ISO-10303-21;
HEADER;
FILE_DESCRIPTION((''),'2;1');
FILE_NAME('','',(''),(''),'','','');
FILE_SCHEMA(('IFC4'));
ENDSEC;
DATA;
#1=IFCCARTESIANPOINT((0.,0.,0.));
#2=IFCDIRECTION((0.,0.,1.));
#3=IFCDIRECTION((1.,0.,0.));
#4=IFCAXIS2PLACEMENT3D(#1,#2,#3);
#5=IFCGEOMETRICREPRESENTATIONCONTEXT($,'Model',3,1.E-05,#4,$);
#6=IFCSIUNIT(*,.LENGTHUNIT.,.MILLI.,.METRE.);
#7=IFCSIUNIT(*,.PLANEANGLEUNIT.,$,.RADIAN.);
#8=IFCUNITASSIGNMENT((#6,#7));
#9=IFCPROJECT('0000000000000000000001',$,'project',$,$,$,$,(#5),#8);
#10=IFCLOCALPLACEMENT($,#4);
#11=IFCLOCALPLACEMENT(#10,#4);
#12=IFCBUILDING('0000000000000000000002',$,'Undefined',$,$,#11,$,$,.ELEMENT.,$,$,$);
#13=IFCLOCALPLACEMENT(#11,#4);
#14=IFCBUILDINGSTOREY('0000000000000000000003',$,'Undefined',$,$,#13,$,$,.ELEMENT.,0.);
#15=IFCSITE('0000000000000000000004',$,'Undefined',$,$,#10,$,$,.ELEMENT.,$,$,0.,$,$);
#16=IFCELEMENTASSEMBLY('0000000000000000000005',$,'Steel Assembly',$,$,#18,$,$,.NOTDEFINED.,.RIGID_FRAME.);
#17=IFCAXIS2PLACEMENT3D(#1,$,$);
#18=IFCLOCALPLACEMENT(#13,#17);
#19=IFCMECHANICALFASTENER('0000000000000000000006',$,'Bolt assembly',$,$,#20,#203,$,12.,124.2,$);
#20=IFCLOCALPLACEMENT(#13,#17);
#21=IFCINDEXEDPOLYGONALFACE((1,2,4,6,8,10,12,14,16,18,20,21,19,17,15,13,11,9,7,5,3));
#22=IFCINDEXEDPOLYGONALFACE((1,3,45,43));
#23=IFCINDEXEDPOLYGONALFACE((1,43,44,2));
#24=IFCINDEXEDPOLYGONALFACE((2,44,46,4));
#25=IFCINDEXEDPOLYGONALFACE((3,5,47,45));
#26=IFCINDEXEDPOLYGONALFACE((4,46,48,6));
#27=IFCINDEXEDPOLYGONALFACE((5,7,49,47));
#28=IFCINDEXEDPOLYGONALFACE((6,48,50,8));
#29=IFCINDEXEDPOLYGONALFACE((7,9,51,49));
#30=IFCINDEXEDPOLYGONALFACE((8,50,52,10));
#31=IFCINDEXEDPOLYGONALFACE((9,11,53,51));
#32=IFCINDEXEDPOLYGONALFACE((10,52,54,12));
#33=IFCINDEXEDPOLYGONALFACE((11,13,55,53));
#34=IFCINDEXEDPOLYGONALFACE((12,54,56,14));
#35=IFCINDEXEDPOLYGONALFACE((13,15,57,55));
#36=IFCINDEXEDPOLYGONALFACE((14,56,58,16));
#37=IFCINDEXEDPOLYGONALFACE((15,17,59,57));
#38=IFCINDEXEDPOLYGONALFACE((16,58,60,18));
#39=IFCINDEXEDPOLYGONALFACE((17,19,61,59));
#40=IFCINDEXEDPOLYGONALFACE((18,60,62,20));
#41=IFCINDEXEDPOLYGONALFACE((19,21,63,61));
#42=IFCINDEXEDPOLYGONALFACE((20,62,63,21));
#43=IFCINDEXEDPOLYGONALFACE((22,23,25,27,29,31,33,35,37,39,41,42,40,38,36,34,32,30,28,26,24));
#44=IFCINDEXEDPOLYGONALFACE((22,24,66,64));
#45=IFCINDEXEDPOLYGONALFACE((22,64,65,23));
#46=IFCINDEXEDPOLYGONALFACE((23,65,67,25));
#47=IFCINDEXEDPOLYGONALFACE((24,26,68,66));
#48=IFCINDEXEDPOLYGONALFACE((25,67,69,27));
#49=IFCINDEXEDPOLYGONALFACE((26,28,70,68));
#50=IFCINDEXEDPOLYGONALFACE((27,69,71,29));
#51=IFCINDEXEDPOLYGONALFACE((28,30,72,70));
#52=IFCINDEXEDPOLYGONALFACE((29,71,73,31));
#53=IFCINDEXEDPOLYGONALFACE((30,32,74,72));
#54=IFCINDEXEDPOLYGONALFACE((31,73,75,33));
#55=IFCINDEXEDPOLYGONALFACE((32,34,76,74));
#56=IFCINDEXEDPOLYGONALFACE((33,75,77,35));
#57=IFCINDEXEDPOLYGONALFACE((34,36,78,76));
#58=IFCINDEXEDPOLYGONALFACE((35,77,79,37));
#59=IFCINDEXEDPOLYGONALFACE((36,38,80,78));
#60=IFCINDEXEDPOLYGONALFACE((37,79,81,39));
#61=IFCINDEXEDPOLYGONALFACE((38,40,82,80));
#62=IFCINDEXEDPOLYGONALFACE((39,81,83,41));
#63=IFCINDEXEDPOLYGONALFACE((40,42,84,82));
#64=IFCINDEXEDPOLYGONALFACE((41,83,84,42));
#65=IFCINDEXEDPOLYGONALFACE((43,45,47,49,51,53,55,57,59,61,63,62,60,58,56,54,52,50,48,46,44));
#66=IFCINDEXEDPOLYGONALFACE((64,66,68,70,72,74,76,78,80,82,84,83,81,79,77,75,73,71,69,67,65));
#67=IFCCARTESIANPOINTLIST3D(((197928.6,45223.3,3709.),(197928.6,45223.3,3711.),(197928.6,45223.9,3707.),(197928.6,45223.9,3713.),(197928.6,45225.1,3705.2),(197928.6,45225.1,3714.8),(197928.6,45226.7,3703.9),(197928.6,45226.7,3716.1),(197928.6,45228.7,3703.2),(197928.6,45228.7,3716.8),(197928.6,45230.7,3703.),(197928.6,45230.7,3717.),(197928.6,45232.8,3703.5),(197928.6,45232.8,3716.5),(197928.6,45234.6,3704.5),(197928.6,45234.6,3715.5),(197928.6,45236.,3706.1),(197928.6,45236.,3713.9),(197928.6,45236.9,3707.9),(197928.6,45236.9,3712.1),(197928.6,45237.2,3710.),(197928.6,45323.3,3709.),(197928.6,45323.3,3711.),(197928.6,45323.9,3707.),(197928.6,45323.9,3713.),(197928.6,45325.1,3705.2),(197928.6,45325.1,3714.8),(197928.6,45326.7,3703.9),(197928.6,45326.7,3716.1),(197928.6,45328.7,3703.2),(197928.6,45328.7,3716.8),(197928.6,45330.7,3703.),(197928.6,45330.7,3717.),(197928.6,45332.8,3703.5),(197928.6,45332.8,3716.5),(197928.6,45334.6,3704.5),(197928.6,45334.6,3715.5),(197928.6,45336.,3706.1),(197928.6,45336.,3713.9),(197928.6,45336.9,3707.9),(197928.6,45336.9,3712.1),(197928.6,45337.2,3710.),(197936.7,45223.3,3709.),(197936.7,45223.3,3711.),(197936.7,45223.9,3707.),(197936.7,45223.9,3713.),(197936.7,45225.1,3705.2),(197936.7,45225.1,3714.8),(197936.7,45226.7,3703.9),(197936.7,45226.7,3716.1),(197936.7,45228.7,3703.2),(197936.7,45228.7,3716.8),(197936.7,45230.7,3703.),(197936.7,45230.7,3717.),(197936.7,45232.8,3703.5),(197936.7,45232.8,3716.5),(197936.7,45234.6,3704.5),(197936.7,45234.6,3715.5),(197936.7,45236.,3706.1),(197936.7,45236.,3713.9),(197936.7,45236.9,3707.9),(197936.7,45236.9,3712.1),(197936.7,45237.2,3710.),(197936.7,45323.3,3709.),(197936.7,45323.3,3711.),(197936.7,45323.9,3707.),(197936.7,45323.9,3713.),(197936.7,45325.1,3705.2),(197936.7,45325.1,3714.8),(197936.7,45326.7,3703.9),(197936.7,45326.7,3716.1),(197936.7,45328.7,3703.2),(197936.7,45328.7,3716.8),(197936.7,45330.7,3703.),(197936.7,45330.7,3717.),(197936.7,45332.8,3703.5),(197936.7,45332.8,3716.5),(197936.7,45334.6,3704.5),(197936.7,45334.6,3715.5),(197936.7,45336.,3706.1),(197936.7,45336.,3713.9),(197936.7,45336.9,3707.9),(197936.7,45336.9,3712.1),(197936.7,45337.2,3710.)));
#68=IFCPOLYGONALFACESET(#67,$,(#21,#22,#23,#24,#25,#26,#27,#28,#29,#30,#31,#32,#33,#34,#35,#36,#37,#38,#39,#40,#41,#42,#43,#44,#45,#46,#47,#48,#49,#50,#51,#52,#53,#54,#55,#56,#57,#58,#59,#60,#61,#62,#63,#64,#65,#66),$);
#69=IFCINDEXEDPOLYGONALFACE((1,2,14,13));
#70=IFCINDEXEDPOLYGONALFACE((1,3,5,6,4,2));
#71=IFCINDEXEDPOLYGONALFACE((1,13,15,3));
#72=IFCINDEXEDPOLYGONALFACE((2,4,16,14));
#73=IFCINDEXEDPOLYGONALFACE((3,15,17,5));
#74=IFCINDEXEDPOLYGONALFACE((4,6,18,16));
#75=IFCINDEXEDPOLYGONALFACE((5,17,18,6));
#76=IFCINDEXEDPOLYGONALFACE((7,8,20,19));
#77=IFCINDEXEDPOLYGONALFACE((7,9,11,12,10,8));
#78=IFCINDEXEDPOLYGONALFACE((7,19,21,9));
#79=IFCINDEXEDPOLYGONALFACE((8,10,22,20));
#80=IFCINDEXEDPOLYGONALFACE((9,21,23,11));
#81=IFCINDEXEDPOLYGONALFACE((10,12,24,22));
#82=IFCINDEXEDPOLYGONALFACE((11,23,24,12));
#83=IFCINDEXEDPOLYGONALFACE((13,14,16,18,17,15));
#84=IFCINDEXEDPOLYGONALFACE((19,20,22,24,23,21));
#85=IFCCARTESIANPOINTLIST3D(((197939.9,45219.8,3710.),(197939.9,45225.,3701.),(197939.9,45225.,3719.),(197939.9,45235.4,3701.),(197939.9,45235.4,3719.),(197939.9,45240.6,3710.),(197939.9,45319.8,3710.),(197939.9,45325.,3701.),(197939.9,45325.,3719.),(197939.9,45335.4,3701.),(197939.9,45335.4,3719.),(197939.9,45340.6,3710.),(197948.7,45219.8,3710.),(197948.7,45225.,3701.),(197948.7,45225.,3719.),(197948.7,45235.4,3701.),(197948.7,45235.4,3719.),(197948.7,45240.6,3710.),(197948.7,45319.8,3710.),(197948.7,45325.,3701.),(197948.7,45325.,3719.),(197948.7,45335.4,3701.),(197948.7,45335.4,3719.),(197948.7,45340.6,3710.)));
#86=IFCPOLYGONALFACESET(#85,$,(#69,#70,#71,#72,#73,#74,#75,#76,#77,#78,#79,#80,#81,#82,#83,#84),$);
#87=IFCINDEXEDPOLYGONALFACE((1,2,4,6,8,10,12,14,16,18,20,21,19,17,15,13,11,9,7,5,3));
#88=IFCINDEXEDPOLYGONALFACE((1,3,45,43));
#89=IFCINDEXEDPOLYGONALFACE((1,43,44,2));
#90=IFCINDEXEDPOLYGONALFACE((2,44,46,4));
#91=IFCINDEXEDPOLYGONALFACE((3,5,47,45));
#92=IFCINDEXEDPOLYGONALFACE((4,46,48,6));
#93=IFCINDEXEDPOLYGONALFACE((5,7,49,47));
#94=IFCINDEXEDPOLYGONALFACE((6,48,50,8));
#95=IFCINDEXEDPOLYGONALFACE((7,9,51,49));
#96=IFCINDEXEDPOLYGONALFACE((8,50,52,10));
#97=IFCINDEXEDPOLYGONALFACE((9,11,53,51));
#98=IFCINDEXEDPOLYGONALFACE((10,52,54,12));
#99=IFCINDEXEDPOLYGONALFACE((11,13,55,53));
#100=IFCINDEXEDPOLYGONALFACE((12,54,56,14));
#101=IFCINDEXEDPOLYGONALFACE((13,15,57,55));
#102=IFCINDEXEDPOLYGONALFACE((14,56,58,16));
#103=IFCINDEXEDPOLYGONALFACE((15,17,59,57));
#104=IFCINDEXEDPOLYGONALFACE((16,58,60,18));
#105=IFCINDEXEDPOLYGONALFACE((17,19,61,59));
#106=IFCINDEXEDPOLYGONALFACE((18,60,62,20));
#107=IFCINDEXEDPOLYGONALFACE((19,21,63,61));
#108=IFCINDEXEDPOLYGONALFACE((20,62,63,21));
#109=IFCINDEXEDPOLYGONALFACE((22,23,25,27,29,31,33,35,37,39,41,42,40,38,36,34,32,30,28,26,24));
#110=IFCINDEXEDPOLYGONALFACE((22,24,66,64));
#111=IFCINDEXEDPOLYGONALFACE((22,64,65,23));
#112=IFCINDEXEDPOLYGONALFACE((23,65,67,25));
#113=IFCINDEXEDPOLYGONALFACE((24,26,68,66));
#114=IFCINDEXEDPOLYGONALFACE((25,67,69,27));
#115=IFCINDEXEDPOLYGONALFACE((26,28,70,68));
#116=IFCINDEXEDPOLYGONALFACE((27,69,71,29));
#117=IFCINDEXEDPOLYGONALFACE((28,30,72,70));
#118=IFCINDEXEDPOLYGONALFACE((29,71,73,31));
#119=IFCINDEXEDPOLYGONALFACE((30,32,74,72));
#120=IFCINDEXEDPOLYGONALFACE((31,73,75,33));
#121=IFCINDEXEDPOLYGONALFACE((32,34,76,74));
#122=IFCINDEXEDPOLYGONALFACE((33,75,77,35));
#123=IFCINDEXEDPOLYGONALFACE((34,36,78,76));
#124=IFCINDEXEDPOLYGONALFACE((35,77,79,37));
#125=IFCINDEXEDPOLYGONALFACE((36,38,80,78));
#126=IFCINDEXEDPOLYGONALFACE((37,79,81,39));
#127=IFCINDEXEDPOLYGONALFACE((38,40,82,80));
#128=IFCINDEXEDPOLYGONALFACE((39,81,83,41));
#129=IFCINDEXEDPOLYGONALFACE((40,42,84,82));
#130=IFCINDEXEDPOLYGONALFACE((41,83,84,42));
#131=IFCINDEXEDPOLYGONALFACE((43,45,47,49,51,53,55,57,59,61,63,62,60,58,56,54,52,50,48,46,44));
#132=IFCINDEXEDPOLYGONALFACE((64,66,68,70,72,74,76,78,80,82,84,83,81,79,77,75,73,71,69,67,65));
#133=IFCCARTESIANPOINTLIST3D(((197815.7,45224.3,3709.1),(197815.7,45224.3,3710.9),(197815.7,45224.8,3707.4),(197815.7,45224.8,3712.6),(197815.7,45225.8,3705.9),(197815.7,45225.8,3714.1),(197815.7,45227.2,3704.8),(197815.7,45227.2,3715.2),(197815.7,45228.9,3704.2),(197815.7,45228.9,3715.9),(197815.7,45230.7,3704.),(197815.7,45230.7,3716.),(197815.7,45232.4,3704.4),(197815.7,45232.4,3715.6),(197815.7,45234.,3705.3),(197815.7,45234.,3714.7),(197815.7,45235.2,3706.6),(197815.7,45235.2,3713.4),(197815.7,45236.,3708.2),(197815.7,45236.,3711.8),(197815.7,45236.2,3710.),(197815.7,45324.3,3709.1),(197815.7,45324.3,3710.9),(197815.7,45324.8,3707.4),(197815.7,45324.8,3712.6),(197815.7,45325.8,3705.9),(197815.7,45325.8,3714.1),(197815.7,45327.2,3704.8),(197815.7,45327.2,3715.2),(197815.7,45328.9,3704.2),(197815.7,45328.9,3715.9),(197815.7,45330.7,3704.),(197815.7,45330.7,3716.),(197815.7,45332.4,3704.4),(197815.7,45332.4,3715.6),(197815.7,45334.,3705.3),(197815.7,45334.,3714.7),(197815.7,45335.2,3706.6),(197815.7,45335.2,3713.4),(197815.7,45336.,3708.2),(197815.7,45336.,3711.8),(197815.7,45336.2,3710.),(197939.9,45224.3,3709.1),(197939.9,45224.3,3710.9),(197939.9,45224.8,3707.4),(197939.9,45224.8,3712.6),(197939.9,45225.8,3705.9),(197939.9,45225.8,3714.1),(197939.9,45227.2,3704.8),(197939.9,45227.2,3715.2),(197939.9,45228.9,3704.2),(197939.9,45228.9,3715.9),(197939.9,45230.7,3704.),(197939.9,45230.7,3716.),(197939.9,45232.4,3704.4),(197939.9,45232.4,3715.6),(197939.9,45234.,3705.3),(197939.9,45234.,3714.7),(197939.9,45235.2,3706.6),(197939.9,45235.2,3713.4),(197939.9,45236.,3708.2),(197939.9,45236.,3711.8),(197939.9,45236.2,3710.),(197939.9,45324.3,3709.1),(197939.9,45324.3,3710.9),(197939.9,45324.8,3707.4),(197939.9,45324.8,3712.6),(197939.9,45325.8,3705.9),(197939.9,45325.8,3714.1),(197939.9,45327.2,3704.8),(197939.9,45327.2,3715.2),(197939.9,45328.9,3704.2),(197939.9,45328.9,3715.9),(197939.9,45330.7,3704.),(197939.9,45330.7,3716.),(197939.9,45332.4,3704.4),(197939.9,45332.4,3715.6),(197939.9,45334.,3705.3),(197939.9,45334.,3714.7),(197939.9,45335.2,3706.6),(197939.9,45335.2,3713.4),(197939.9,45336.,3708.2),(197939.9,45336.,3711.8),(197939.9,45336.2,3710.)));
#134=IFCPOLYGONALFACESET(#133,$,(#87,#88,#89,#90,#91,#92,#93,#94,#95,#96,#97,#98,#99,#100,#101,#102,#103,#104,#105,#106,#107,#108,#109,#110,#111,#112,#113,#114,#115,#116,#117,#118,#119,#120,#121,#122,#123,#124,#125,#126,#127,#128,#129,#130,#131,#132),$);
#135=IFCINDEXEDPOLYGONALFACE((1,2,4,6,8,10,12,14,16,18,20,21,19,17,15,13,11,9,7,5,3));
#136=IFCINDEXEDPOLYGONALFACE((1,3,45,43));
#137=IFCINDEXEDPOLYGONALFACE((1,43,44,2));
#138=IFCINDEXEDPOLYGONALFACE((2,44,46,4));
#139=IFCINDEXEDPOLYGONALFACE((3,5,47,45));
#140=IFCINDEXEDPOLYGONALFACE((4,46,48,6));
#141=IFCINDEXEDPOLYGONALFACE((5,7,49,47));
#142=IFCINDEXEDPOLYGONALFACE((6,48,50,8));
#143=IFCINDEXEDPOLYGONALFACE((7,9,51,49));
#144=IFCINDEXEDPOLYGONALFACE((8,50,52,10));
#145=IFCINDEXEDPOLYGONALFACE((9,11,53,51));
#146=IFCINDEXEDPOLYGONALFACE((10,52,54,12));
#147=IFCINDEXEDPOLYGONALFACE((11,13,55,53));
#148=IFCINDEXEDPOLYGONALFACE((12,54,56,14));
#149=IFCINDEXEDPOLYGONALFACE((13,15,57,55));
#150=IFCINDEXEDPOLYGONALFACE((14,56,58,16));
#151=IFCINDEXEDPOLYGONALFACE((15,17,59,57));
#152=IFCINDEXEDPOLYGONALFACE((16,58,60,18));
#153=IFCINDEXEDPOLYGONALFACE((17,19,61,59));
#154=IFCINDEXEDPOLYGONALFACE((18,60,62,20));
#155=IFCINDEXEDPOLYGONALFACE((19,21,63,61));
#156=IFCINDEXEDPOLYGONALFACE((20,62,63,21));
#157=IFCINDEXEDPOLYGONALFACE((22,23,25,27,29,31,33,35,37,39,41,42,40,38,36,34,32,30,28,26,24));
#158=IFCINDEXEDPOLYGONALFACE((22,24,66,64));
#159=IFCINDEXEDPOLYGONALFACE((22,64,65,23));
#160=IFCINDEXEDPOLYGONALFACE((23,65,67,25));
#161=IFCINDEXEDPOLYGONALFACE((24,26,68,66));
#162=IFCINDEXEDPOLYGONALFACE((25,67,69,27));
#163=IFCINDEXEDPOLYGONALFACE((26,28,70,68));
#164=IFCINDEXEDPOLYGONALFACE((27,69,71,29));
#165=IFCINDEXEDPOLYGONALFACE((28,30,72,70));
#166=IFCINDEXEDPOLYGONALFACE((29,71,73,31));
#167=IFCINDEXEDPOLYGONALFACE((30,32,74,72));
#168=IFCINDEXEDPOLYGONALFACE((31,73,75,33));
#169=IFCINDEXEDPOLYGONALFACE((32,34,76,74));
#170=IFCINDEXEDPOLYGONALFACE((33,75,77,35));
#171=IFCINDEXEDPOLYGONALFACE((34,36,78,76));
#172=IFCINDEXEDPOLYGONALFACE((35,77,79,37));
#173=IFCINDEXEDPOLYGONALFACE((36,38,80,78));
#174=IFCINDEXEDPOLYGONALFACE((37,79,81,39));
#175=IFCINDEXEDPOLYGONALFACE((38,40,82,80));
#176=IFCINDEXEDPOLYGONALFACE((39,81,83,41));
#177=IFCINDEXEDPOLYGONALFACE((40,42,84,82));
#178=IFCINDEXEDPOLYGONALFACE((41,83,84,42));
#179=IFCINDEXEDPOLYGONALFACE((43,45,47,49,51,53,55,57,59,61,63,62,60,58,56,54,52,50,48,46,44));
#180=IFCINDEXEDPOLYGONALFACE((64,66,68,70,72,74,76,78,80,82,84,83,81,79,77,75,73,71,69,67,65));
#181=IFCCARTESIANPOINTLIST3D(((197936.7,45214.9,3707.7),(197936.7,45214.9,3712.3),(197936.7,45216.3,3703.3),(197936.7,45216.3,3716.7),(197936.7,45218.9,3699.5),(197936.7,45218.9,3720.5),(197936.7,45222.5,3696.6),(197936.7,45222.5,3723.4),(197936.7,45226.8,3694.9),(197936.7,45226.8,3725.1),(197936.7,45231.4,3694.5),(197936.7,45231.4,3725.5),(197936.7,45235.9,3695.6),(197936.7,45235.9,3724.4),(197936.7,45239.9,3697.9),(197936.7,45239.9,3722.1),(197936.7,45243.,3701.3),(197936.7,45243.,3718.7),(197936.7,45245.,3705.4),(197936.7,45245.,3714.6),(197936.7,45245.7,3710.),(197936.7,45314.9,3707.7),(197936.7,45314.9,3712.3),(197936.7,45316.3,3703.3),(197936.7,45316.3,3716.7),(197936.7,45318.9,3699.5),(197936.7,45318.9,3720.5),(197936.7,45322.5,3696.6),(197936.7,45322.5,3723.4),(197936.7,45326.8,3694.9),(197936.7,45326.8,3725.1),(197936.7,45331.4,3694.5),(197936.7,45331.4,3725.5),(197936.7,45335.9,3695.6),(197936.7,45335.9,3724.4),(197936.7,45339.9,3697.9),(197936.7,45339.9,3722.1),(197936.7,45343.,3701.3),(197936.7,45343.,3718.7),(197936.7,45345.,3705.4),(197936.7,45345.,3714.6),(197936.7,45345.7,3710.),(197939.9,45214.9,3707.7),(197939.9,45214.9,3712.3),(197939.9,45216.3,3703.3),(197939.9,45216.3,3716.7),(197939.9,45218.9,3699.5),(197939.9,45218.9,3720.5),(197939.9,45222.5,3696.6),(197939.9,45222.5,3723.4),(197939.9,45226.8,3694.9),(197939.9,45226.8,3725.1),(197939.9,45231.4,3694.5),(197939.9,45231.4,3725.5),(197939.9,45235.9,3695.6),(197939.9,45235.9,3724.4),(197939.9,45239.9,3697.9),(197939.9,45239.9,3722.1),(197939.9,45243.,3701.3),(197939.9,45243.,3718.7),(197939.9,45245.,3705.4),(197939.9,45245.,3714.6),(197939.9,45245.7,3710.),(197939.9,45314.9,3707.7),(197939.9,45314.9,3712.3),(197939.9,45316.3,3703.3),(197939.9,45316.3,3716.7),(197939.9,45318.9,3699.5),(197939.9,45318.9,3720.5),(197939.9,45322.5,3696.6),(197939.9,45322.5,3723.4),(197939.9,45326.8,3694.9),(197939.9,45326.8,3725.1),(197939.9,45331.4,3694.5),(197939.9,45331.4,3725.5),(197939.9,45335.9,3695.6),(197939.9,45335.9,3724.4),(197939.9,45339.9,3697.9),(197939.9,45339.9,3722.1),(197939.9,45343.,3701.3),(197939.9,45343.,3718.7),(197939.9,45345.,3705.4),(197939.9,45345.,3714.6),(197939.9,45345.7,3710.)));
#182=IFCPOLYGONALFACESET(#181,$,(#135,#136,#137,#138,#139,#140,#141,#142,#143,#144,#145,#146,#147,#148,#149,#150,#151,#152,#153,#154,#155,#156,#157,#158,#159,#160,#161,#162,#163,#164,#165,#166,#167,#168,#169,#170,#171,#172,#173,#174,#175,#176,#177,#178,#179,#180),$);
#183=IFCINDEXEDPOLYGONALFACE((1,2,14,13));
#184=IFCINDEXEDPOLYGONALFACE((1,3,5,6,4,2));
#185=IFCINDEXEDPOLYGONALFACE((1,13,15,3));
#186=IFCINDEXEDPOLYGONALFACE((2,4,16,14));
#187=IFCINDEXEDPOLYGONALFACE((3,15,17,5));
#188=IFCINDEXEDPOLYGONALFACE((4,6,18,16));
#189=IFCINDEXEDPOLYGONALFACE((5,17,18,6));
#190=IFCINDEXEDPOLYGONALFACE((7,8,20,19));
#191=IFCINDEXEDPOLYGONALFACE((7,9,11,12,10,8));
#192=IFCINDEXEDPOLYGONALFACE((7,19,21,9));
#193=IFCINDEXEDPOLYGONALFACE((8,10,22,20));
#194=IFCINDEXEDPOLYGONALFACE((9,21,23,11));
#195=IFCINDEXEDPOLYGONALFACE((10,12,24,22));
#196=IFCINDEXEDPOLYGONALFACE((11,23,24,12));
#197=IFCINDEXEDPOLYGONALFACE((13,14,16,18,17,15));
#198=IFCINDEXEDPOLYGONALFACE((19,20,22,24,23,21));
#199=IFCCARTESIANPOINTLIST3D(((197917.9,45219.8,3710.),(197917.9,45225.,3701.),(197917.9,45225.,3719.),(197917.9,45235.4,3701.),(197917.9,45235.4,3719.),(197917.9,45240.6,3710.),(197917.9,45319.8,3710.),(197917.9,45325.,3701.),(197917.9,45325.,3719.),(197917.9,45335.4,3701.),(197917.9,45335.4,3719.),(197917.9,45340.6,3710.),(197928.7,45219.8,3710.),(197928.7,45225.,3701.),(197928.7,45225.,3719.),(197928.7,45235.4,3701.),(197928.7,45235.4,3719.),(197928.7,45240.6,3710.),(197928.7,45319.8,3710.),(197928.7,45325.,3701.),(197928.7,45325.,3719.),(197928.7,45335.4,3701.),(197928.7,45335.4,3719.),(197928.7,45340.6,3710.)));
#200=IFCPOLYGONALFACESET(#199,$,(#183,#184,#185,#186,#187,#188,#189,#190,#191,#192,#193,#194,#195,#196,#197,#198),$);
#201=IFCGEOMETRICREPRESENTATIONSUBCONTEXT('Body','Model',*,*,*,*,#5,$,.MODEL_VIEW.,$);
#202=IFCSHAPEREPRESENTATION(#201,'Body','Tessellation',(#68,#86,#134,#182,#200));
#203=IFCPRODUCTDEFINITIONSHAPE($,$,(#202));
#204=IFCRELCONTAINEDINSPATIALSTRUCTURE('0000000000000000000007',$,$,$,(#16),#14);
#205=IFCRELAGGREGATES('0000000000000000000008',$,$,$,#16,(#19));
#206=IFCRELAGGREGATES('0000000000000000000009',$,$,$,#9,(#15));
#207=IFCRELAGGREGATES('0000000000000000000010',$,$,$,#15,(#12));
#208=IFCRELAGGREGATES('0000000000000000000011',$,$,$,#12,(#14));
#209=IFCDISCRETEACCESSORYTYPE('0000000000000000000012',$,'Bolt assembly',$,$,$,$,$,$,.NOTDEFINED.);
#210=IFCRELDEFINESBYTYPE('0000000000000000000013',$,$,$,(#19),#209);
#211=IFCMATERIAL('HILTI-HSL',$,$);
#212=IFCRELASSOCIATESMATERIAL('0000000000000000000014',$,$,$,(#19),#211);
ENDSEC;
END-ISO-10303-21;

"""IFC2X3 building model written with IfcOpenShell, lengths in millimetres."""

from ifc_helpers import new_model, si_unit, frame, origin_with_axes, origin_2d_with_axis, place, context, subcontext, project, spatial, polyline, circle, outline, extrude, source, transform, mapped, material, type_object, element, aggregate, save


model = new_model("IFC2X3")

# Units and contexts
model_context = context("Model", 3, precision=1e-05, world=origin_with_axes())
body_context = subcontext(model_context, "Body", "Model", "MODEL_VIEW")
ifc_project = project(units=[si_unit("LENGTHUNIT", "METRE", prefix="MILLI"), si_unit("PLANEANGLEUNIT", "RADIAN")], contexts=[model_context])

# Site, building, storey
site_placement = place(None, origin_with_axes())
site = spatial("IfcSite", under=ifc_project, at=site_placement, Name="Undefined", CompositionType="ELEMENT", RefElevation=0.0)
building_placement = place(site_placement, origin_with_axes())
building = spatial("IfcBuilding", under=site, at=building_placement, Name="Undefined", CompositionType="ELEMENT")
storey_placement = place(building_placement, origin_with_axes())
storey = spatial("IfcBuildingStorey", under=building, at=storey_placement, Name="Undefined", CompositionType="ELEMENT", Elevation=0.0)

# Element assembly
assembly_1_placement = place(storey_placement, origin_with_axes())
assembly_1 = element("IfcElementAssembly", 1, at=assembly_1_placement, inside=storey, Name="Steel Assembly", AssemblyPlace="NOTDEFINED", PredefinedType="RIGID_FRAME")

# Shared definitions
discrete_accessory_type_1 = type_object("IfcDiscreteAccessoryType", Name="Bolt assembly")

# Mechanical fastener
ifc_material_1 = material(Name="HILTI-HSL")
shared_shape_1 = source(origin_with_axes(), body_context, "Body", "SweptSolid", [
    extrude(circle(Radius=7.0, at=origin_2d_with_axis()), frame((0.0, 0.0, 0.0), z_axis=(0.0, 1.0, 0.0), x_axis=(1.0, 0.0, 0.0)), (0.0, 0.0, 1.0), 8.1),
    extrude(outline(polyline([(10.4, 0.0), (5.2, 9.0), (-5.2, 9.0), (-10.4, 0.0), (-5.2, -9.0), (5.2, -9.0), (10.4, 0.0)])), frame((0.0, -12.0, 0.0), z_axis=(0.0, 1.0, 0.0), x_axis=(1.0, 0.0, 0.0)), (0.0, 0.0, 1.0), 8.8),
    extrude(circle(Radius=6.0, at=origin_2d_with_axis()), frame((0.0, -3.2, 0.0), z_axis=(0.0, 1.0, 0.0), x_axis=(1.0, 0.0, 0.0)), (0.0, 0.0, 1.0), 124.2),
    extrude(circle(Radius=15.5, at=origin_2d_with_axis()), frame((0.0, -3.2, 0.0), z_axis=(0.0, 1.0, 0.0), x_axis=(1.0, 0.0, 0.0)), (0.0, 0.0, 1.0), 3.2),
    extrude(outline(polyline([(10.4, 0.0), (5.2, 9.0), (-5.2, 9.0), (-10.4, 0.0), (-5.2, -9.0), (5.2, -9.0), (10.4, 0.0)])), frame((0.0, 8.0, 0.0), z_axis=(0.0, 1.0, 0.0), x_axis=(1.0, 0.0, 0.0)), (0.0, 0.0, 1.0), 10.8),
])
mechanical_fastener_1_placement = place(assembly_1_placement, frame((197936.7, 45180.2, 3620.0), z_axis=(0.0, 0.0, 1.0), x_axis=(0.0, 1.0, 0.0)))
mechanical_fastener_1 = element("IfcMechanicalFastener", 2, at=mechanical_fastener_1_placement, type_object=discrete_accessory_type_1, material=ifc_material_1, Name="Bolt assembly", NominalDiameter=12.0, NominalLength=124.2, context=body_context, shape_type="MappedRepresentation", body=[
    mapped(shared_shape_1, transform((150.0, 0.0, 90.0))),
    mapped(shared_shape_1, transform((50.0, 0.0, 90.0))),
])
aggregate(assembly_1, [mechanical_fastener_1])

save(model, "model.ifc")
